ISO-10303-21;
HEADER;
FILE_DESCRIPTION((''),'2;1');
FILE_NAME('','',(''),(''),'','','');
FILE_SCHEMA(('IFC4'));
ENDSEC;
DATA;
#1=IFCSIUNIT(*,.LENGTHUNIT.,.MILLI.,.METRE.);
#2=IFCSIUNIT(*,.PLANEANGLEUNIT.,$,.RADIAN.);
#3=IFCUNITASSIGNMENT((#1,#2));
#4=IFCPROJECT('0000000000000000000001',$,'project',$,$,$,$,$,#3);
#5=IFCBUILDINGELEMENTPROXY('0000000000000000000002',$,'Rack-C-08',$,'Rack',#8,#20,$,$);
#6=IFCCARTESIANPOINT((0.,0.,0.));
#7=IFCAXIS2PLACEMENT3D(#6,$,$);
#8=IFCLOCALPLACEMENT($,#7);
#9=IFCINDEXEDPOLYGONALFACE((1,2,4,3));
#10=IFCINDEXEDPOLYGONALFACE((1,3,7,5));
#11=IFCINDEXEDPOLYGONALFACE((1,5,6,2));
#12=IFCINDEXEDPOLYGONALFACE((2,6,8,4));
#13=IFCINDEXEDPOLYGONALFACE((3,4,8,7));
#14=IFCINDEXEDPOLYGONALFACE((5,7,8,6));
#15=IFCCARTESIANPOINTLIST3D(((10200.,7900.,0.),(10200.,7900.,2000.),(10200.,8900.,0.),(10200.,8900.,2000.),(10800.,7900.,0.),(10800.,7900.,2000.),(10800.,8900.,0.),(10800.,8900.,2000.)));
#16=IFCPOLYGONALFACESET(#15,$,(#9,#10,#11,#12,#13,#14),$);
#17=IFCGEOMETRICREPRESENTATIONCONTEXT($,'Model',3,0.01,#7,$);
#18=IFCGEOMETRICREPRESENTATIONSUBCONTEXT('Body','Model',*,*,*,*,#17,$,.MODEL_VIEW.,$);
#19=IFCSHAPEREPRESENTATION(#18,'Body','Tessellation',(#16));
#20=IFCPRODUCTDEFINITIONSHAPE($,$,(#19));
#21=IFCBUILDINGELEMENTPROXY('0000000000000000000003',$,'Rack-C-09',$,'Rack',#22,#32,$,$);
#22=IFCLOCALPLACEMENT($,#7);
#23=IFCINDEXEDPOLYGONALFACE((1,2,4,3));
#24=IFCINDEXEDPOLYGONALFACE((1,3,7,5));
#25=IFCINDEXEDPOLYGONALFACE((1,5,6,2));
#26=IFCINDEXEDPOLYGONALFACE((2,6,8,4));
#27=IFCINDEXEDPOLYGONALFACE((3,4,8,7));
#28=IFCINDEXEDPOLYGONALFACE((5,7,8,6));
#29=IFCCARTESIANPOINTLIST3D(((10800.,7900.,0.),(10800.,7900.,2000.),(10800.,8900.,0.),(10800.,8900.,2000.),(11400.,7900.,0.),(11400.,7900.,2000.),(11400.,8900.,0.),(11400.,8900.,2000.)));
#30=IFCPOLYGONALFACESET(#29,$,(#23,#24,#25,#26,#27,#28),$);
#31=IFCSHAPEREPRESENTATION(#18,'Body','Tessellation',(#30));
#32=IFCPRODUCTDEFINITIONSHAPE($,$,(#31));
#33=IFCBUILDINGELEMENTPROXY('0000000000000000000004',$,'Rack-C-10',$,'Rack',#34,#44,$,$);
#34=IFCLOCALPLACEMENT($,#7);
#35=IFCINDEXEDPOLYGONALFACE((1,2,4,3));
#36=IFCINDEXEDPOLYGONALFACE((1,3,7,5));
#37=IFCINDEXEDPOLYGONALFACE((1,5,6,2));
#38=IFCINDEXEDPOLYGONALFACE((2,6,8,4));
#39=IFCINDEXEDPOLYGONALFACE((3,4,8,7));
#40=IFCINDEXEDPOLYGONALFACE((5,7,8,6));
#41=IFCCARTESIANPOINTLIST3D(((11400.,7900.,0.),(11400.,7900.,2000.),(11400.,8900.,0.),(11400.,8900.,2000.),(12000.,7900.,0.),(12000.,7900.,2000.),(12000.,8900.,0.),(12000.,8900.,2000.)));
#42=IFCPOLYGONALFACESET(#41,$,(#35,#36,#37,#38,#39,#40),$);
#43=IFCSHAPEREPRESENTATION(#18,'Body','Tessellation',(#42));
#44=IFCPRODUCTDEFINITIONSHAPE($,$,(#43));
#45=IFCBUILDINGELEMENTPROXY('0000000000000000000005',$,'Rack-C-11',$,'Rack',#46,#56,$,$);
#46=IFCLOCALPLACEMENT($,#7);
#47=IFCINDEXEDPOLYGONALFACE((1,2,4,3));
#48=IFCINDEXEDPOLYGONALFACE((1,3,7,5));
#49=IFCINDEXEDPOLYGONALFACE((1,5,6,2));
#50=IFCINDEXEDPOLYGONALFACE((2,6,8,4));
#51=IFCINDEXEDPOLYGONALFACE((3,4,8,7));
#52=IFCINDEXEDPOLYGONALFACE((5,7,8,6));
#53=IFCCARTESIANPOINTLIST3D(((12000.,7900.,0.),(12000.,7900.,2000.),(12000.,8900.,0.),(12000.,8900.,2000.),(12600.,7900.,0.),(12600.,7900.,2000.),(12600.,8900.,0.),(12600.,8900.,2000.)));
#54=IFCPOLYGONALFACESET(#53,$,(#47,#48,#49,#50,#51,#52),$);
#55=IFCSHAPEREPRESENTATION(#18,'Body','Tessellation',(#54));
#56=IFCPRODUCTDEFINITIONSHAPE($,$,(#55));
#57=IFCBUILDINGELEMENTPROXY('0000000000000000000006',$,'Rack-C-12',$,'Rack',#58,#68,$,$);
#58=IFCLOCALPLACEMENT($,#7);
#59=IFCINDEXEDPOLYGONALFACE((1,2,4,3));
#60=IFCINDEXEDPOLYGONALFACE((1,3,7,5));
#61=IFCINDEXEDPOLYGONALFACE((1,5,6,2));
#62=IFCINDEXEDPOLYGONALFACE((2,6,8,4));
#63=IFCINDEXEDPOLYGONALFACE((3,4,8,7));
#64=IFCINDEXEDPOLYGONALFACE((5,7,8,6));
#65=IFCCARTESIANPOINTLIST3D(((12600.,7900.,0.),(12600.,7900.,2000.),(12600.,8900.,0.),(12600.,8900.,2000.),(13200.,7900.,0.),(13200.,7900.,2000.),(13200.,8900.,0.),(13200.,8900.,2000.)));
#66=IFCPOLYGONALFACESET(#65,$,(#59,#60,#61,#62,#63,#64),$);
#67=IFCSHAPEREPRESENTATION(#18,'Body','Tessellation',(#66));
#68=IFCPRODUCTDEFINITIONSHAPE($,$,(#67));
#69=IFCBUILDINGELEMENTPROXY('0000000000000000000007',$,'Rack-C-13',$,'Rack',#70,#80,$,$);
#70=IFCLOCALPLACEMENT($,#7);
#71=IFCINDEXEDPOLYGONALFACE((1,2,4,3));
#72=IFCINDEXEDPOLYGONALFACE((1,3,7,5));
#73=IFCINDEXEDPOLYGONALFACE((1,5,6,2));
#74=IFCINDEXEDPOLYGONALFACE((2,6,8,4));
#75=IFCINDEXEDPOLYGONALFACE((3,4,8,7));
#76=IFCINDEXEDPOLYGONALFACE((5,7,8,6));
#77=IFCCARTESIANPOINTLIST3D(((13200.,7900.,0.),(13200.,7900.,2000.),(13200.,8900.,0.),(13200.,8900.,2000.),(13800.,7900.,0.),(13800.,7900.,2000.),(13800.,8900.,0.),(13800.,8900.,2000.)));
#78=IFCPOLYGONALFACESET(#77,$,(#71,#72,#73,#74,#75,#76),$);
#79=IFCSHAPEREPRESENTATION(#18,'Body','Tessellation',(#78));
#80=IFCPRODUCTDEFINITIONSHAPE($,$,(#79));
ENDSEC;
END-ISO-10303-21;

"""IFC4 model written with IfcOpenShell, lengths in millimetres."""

from ifc_helpers import new_model, si_unit, frame, origin, place, context, subcontext, project, rectangle, extrude, element, save


model = new_model("IFC4")

# Units and contexts
model_context = context("Model", 3, precision=0.01, world=origin())
body_context = subcontext(model_context, "Body", "Model", "MODEL_VIEW")
ifc_project = project(units=[si_unit("LENGTHUNIT", "METRE", prefix="MILLI"), si_unit("PLANEANGLEUNIT", "RADIAN")])

# Shared definitions
placement = place(None, origin())

# Building element proxies
for number, where, name in (
    (1, (10500.0, 8400.0, 0.0), "Rack-C-08"),
    (2, (11100.0, 8400.0, 0.0), "Rack-C-09"),
    (3, (11700.0, 8400.0, 0.0), "Rack-C-10"),
    (4, (12300.0, 8400.0, 0.0), "Rack-C-11"),
    (5, (12900.0, 8400.0, 0.0), "Rack-C-12"),
    (6, (13500.0, 8400.0, 0.0), "Rack-C-13"),
):
    element("IfcBuildingElementProxy", number, at=place(placement, frame(where)), Name=name, ObjectType="Rack", context=body_context, shape_type="SweptSolid", body=[
        extrude(rectangle(XDim=600.0, YDim=1000.0), origin(), (0.0, 0.0, 1.0), 2000.0),
    ])

save(model, "model.ifc")
